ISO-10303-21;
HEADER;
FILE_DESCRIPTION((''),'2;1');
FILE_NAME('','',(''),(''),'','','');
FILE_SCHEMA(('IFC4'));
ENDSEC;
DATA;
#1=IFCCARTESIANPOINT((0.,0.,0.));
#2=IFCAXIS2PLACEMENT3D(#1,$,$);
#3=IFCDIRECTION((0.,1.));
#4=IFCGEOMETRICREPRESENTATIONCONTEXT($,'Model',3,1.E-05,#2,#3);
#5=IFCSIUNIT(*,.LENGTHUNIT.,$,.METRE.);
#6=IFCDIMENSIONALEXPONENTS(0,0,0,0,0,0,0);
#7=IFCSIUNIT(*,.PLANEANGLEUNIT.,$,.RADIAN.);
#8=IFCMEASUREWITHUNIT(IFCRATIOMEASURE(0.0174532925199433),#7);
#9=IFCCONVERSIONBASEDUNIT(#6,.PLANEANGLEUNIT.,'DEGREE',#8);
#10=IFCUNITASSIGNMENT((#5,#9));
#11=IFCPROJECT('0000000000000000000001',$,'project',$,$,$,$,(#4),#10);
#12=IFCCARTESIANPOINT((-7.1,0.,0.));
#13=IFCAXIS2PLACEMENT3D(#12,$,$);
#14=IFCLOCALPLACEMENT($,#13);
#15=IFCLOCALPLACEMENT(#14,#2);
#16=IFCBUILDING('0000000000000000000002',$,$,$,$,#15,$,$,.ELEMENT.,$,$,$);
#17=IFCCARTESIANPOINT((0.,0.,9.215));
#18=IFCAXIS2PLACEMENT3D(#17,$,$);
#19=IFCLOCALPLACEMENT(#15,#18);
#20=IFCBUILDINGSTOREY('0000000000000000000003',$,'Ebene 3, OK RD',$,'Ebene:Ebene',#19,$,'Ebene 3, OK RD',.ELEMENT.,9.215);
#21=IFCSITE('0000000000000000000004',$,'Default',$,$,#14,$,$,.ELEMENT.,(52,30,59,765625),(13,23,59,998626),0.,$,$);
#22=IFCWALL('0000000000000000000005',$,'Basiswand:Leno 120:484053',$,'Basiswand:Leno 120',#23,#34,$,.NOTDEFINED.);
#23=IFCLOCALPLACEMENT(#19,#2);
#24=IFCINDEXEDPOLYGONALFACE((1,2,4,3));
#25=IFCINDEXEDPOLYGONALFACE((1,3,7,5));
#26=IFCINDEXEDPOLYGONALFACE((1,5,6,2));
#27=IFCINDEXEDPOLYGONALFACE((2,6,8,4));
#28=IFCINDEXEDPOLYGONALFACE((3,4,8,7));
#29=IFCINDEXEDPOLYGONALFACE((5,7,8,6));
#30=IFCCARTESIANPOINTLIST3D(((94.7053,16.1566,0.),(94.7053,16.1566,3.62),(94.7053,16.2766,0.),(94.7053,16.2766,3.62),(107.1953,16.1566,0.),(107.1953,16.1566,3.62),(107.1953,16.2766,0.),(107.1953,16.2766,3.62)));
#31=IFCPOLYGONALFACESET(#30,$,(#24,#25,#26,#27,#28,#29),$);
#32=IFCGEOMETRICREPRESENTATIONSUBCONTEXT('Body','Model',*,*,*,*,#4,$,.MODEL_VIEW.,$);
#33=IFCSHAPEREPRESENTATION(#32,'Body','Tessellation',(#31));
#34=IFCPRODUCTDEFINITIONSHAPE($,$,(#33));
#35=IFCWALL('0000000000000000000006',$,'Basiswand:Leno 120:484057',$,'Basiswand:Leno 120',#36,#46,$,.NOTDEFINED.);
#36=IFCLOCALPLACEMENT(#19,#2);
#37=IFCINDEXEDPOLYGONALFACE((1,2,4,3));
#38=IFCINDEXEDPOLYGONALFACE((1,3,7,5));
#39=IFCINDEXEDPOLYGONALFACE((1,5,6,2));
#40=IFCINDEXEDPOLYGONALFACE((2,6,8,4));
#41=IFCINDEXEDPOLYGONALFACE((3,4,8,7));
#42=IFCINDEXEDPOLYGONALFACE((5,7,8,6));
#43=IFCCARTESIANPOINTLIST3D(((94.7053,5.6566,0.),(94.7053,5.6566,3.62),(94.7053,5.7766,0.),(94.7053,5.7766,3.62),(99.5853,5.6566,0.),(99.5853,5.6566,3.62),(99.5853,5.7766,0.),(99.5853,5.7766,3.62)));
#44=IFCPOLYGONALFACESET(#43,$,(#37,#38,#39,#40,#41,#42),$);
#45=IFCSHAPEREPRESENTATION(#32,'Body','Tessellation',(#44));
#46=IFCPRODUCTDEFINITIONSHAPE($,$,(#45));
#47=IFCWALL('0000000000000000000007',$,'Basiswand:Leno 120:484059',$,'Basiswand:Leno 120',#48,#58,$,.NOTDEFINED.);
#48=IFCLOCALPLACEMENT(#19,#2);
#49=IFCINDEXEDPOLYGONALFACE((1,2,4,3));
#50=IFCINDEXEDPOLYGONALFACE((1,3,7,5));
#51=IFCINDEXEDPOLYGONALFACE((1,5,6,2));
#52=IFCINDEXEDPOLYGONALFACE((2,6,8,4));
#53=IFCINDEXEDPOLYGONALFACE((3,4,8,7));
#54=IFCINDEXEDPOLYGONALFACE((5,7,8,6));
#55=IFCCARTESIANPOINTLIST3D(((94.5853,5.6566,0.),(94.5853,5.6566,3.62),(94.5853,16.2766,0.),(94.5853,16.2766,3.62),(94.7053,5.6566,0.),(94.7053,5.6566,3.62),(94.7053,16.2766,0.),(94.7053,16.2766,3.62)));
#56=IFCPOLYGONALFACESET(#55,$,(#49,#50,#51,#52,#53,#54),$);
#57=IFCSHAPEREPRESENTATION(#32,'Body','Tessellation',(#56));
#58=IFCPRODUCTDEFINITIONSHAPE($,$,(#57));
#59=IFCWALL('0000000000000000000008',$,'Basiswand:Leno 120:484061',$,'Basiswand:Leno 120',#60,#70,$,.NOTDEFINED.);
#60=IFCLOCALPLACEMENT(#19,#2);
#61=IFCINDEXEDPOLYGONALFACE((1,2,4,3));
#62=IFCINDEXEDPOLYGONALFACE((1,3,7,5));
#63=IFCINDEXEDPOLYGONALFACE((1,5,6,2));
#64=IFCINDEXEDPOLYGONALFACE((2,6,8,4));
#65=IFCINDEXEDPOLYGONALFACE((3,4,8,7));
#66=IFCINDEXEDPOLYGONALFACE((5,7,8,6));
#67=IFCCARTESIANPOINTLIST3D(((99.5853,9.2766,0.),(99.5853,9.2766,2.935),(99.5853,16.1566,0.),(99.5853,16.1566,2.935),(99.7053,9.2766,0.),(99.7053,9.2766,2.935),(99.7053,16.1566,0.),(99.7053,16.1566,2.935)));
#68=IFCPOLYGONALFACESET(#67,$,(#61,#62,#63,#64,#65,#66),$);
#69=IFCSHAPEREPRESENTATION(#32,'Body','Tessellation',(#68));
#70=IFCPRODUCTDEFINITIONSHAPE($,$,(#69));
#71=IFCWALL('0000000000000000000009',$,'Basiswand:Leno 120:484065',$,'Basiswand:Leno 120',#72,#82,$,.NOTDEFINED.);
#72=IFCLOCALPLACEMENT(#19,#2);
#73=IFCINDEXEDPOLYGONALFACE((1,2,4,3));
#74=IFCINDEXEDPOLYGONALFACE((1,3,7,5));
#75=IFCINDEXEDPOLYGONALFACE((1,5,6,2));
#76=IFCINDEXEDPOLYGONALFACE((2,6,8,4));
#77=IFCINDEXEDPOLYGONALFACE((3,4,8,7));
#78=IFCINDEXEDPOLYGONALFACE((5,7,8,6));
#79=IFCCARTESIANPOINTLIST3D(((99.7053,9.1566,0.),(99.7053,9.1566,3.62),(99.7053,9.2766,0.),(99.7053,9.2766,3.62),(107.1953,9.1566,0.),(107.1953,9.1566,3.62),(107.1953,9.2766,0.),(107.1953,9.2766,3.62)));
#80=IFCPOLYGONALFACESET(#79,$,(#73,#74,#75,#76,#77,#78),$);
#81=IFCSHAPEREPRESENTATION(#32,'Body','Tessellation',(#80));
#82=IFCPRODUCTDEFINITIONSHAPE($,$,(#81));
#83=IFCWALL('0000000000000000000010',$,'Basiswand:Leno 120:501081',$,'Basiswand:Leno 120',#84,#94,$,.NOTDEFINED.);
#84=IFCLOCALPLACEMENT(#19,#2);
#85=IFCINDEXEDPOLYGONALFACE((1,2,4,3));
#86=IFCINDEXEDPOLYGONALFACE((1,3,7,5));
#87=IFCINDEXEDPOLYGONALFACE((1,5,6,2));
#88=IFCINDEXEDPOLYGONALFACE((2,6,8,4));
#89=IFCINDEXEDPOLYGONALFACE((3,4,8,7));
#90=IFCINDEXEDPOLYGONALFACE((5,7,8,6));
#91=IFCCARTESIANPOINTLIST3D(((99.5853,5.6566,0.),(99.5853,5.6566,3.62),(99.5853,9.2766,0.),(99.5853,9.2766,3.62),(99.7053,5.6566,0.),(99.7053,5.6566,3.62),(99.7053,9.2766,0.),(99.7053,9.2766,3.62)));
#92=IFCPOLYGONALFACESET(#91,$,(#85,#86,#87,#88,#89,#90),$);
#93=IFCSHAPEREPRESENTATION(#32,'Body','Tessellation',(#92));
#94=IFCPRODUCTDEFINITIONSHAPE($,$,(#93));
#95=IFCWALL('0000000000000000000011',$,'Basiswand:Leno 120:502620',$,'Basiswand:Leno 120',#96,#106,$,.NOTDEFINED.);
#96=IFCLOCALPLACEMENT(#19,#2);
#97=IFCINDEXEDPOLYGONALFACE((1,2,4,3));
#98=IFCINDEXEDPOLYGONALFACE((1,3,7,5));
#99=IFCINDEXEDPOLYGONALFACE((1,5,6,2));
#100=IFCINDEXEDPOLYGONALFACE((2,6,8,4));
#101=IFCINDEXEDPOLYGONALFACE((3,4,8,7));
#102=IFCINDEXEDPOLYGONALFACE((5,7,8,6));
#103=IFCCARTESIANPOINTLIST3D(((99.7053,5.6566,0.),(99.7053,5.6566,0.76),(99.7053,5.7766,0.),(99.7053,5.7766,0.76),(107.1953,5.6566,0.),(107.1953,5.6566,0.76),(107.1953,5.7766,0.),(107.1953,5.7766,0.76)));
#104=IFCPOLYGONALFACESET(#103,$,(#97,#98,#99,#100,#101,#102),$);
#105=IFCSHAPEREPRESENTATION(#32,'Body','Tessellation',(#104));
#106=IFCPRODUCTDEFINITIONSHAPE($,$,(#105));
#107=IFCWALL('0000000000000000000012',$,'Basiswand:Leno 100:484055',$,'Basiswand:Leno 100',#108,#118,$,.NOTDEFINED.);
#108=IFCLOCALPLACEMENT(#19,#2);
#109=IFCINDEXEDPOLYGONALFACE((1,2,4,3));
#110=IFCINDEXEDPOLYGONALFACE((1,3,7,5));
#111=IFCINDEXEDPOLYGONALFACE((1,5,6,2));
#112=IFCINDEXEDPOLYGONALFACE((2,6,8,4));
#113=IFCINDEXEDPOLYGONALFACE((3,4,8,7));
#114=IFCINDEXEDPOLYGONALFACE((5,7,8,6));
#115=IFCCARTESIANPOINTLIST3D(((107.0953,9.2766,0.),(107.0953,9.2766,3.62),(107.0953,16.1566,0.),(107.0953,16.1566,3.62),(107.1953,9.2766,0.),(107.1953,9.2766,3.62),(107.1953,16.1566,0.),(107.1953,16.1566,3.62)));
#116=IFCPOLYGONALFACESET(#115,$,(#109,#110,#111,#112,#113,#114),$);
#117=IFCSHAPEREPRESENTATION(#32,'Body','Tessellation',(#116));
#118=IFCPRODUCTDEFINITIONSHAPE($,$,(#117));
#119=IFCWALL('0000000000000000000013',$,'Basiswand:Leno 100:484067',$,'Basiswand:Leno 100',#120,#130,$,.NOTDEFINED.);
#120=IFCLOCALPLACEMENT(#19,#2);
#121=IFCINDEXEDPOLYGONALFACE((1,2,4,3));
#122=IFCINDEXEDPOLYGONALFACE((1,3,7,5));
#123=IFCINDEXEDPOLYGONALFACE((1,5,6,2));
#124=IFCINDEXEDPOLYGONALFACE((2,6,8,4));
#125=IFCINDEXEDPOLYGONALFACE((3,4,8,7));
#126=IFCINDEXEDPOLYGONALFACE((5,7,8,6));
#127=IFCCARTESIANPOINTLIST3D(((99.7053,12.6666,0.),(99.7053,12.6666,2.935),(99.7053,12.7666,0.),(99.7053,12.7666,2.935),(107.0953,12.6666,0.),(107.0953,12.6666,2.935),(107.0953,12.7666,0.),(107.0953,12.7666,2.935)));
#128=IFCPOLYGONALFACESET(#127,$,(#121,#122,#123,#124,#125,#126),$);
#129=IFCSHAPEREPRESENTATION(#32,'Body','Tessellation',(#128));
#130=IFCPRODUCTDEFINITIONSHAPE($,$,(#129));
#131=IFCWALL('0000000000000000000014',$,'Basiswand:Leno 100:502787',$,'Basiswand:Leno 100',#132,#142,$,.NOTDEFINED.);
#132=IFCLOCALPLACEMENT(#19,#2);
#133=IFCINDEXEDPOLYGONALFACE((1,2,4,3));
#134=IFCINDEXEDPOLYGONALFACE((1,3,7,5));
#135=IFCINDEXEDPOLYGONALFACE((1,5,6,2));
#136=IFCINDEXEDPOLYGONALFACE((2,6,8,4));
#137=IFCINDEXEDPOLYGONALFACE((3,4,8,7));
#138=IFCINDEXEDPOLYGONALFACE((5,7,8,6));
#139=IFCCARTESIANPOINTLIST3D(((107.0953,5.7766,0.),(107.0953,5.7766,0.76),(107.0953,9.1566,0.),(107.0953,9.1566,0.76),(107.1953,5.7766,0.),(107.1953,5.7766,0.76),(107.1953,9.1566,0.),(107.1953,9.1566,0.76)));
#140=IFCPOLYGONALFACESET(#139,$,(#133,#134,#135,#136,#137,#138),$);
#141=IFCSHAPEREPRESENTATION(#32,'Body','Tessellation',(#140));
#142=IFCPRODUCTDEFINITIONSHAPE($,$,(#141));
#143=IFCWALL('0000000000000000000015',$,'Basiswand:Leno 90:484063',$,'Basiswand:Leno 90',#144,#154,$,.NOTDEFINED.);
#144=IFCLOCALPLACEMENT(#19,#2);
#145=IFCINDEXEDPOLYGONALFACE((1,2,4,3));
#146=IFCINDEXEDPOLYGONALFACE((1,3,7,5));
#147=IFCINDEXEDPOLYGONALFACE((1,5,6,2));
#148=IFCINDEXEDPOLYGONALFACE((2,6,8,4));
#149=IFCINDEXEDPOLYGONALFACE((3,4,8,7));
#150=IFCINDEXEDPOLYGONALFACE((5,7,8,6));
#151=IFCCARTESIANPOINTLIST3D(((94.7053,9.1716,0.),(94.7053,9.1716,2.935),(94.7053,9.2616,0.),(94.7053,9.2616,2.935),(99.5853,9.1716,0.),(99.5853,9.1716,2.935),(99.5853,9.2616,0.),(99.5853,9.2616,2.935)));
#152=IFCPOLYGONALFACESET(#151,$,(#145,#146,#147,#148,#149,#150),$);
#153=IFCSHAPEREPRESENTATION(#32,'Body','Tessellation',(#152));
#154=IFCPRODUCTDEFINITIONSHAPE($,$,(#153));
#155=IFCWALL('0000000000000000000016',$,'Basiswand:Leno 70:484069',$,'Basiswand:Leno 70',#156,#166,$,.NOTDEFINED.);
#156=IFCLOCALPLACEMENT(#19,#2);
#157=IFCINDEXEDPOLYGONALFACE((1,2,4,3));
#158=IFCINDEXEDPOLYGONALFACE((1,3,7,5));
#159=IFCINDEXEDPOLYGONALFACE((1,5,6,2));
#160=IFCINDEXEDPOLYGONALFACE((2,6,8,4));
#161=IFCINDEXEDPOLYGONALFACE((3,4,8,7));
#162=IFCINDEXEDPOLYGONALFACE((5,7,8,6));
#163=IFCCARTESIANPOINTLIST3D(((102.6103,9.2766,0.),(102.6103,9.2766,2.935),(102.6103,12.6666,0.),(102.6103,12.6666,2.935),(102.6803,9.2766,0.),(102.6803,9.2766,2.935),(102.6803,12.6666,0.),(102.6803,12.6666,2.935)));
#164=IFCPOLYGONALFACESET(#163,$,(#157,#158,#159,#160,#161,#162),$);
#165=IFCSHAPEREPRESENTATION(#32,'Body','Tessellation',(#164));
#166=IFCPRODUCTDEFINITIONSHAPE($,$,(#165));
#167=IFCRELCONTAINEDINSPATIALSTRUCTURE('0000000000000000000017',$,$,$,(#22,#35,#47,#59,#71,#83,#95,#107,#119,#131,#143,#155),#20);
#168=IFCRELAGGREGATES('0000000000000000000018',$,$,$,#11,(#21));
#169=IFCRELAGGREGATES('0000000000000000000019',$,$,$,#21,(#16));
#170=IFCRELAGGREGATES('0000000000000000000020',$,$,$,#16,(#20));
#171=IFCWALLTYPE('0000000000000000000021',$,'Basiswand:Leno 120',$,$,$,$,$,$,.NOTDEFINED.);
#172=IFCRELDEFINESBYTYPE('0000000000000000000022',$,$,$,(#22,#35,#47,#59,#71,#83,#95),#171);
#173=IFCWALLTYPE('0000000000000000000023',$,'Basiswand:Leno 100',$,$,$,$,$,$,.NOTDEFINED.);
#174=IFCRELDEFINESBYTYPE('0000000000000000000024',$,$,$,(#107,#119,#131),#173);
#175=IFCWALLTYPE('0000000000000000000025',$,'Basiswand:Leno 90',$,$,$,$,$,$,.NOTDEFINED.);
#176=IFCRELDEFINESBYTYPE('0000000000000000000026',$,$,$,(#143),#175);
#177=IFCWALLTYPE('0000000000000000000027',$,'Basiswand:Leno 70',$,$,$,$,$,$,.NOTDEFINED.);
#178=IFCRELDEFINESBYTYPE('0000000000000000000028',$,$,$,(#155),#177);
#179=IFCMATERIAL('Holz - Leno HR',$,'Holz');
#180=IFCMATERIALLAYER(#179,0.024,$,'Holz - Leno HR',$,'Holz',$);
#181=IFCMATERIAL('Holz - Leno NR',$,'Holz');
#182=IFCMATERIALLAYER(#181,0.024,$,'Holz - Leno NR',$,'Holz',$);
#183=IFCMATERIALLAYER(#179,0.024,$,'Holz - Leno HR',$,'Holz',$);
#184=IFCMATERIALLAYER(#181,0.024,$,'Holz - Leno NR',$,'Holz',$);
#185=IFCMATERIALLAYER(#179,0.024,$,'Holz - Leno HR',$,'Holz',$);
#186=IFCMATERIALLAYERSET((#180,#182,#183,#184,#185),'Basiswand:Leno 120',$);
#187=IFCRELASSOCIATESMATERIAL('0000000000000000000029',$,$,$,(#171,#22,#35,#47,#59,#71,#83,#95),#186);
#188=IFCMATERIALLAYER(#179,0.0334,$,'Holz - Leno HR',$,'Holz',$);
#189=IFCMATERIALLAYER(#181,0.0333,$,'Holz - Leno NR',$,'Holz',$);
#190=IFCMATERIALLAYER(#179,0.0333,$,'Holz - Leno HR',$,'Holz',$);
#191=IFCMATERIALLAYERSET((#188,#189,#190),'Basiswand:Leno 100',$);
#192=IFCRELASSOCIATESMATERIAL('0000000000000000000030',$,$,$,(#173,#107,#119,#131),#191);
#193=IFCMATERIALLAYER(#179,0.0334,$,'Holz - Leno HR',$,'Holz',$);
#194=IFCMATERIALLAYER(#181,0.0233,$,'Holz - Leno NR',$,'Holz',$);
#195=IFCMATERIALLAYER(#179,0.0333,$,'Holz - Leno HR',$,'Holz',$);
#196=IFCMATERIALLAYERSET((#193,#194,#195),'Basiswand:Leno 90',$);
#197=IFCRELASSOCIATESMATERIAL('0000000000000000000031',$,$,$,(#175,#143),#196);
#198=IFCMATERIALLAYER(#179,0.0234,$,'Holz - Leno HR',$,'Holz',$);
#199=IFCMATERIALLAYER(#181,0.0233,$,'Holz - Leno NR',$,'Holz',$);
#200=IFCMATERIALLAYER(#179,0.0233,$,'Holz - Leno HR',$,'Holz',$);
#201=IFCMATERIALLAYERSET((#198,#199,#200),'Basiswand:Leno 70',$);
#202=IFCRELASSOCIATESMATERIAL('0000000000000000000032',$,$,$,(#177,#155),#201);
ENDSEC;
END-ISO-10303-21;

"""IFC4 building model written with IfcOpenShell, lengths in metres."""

from ifc_helpers import new_model, entity, si_unit, converted_unit, direction, frame, frame_2d, origin, place, context, subcontext, project, spatial, rectangle, extrude, material, layer, layer_set, layer_usage, type_object, element, save


model = new_model("IFC4")

# Units and contexts
model_context = context("Model", 3, precision=1e-05, world=origin(), true_north=direction((0.0, 1.0)))
body_context = subcontext(model_context, "Body", "Model", "MODEL_VIEW")
ifc_project = project(units=[si_unit("LENGTHUNIT", "METRE"), converted_unit("PLANEANGLEUNIT", "DEGREE", entity("IfcRatioMeasure", 0.0174532925199433), si_unit("PLANEANGLEUNIT", "RADIAN"), dimensions=[0, 0, 0, 0, 0, 0, 0])], contexts=[model_context])

# Site, building, storey
site_placement = place(None, frame((-7.1, 0.0, 0.0)))
site = spatial("IfcSite", under=ifc_project, at=site_placement, Name="Default", CompositionType="ELEMENT", RefLatitude=(52, 30, 59, 765625), RefLongitude=(13, 23, 59, 998626), RefElevation=0.0)
building_placement = place(site_placement, origin())
building = spatial("IfcBuilding", under=site, at=building_placement, CompositionType="ELEMENT")
storey_placement = place(building_placement, frame((0.0, 0.0, 9.215)))
storey = spatial("IfcBuildingStorey", under=building, at=storey_placement, Name="Ebene 3, OK RD", ObjectType="Ebene:Ebene", LongName="Ebene 3, OK RD", CompositionType="ELEMENT", Elevation=9.215)

# Shared definitions
ifc_material_1 = material(Name="Holz - Leno HR", Category="Holz")
ifc_material_2 = material(Name="Holz - Leno NR", Category="Holz")

# Walls
ifc_layer_1 = layer(ifc_material_1, 0.024, Name="Holz - Leno HR", Category="Holz")
ifc_layer_2 = layer(ifc_material_2, 0.024, Name="Holz - Leno NR", Category="Holz")
ifc_layer_3 = layer(ifc_material_1, 0.024, Name="Holz - Leno HR", Category="Holz")
ifc_layer_4 = layer(ifc_material_2, 0.024, Name="Holz - Leno NR", Category="Holz")
ifc_layer_5 = layer(ifc_material_1, 0.024, Name="Holz - Leno HR", Category="Holz")
ifc_layer_set_1 = layer_set([ifc_layer_1, ifc_layer_2, ifc_layer_3, ifc_layer_4, ifc_layer_5], Name="Basiswand:Leno 120")
ifc_layer_usage_1 = layer_usage(ifc_layer_set_1, "AXIS2", "NEGATIVE", 0.06)
wall_type_1 = type_object("IfcWallType", Name="Basiswand:Leno 120", PredefinedType="NOTDEFINED", material=ifc_layer_set_1)
wall_1_placement = place(storey_placement, frame((94.7053, 16.2166, 0.0)))
element("IfcWall", 1, at=wall_1_placement, inside=storey, type_object=wall_type_1, material=ifc_layer_usage_1, Name="Basiswand:Leno 120:484053", ObjectType="Basiswand:Leno 120", PredefinedType="NOTDEFINED", context=body_context, shape_type="SweptSolid", body=[
    extrude(rectangle(XDim=12.49, YDim=0.12, at=frame_2d((6.245, 0.0), x_axis=(-1.0, 0.0))), origin(), (0.0, 0.0, 1.0), 3.62),
])
ifc_layer_usage_2 = layer_usage(ifc_layer_set_1, "AXIS2", "NEGATIVE", 0.06)
wall_2_placement = place(storey_placement, frame((99.5853, 5.7166, 0.0), z_axis=(0.0, 0.0, 1.0), x_axis=(-1.0, 0.0, 0.0)))
element("IfcWall", 2, at=wall_2_placement, inside=storey, type_object=wall_type_1, material=ifc_layer_usage_2, Name="Basiswand:Leno 120:484057", ObjectType="Basiswand:Leno 120", PredefinedType="NOTDEFINED", context=body_context, shape_type="SweptSolid", body=[
    extrude(rectangle(XDim=4.88, YDim=0.12, at=frame_2d((2.44, 0.0), x_axis=(-1.0, 0.0))), origin(), (0.0, 0.0, 1.0), 3.62),
])
ifc_layer_usage_3 = layer_usage(ifc_layer_set_1, "AXIS2", "NEGATIVE", 0.06)
wall_3_placement = place(storey_placement, frame((94.6453, 5.6566, 0.0), z_axis=(0.0, 0.0, 1.0), x_axis=(0.0, 1.0, 0.0)))
element("IfcWall", 3, at=wall_3_placement, inside=storey, type_object=wall_type_1, material=ifc_layer_usage_3, Name="Basiswand:Leno 120:484059", ObjectType="Basiswand:Leno 120", PredefinedType="NOTDEFINED", context=body_context, shape_type="SweptSolid", body=[
    extrude(rectangle(XDim=10.62, YDim=0.12, at=frame_2d((5.31, 0.0), x_axis=(-1.0, 0.0))), origin(), (0.0, 0.0, 1.0), 3.62),
])
ifc_layer_usage_4 = layer_usage(ifc_layer_set_1, "AXIS2", "NEGATIVE", 0.06)
wall_4_placement = place(storey_placement, frame((99.6453, 16.1566, 0.0), z_axis=(0.0, 0.0, 1.0), x_axis=(0.0, -1.0, 0.0)))
element("IfcWall", 4, at=wall_4_placement, inside=storey, type_object=wall_type_1, material=ifc_layer_usage_4, Name="Basiswand:Leno 120:484061", ObjectType="Basiswand:Leno 120", PredefinedType="NOTDEFINED", context=body_context, shape_type="SweptSolid", body=[
    extrude(rectangle(XDim=6.88, YDim=0.12, at=frame_2d((3.44, 0.0), x_axis=(-1.0, 0.0))), origin(), (0.0, 0.0, 1.0), 2.935),
])
ifc_layer_usage_5 = layer_usage(ifc_layer_set_1, "AXIS2", "NEGATIVE", 0.06)
wall_5_placement = place(storey_placement, frame((107.1953, 9.2166, 0.0), z_axis=(0.0, 0.0, 1.0), x_axis=(-1.0, 0.0, 0.0)))
element("IfcWall", 5, at=wall_5_placement, inside=storey, type_object=wall_type_1, material=ifc_layer_usage_5, Name="Basiswand:Leno 120:484065", ObjectType="Basiswand:Leno 120", PredefinedType="NOTDEFINED", context=body_context, shape_type="SweptSolid", body=[
    extrude(rectangle(XDim=7.49, YDim=0.12, at=frame_2d((3.745, 0.0), x_axis=(-1.0, 0.0))), origin(), (0.0, 0.0, 1.0), 3.62),
])
ifc_layer_usage_6 = layer_usage(ifc_layer_set_1, "AXIS2", "NEGATIVE", 0.06)
wall_6_placement = place(storey_placement, frame((99.6453, 9.2766, 0.0), z_axis=(0.0, 0.0, 1.0), x_axis=(0.0, -1.0, 0.0)))
element("IfcWall", 6, at=wall_6_placement, inside=storey, type_object=wall_type_1, material=ifc_layer_usage_6, Name="Basiswand:Leno 120:501081", ObjectType="Basiswand:Leno 120", PredefinedType="NOTDEFINED", context=body_context, shape_type="SweptSolid", body=[
    extrude(rectangle(XDim=3.62, YDim=0.12, at=frame_2d((1.81, 0.0), x_axis=(-1.0, 0.0))), origin(), (0.0, 0.0, 1.0), 3.62),
])
ifc_layer_usage_7 = layer_usage(ifc_layer_set_1, "AXIS2", "NEGATIVE", 0.06)
wall_7_placement = place(storey_placement, frame((99.7053, 5.7166, 0.0)))
element("IfcWall", 7, at=wall_7_placement, inside=storey, type_object=wall_type_1, material=ifc_layer_usage_7, Name="Basiswand:Leno 120:502620", ObjectType="Basiswand:Leno 120", PredefinedType="NOTDEFINED", context=body_context, shape_type="SweptSolid", body=[
    extrude(rectangle(XDim=7.49, YDim=0.12, at=frame_2d((3.745, 0.0), x_axis=(-1.0, 0.0))), origin(), (0.0, 0.0, 1.0), 0.76),
])
ifc_layer_6 = layer(ifc_material_1, 0.0334, Name="Holz - Leno HR", Category="Holz")
ifc_layer_7 = layer(ifc_material_2, 0.0333, Name="Holz - Leno NR", Category="Holz")
ifc_layer_8 = layer(ifc_material_1, 0.0333, Name="Holz - Leno HR", Category="Holz")
ifc_layer_set_2 = layer_set([ifc_layer_6, ifc_layer_7, ifc_layer_8], Name="Basiswand:Leno 100")
ifc_layer_usage_8 = layer_usage(ifc_layer_set_2, "AXIS2", "NEGATIVE", 0.05)
wall_type_2 = type_object("IfcWallType", Name="Basiswand:Leno 100", PredefinedType="NOTDEFINED", material=ifc_layer_set_2)
wall_8_placement = place(storey_placement, frame((107.1453, 16.1566, 0.0), z_axis=(0.0, 0.0, 1.0), x_axis=(0.0, -1.0, 0.0)))
element("IfcWall", 8, at=wall_8_placement, inside=storey, type_object=wall_type_2, material=ifc_layer_usage_8, Name="Basiswand:Leno 100:484055", ObjectType="Basiswand:Leno 100", PredefinedType="NOTDEFINED", context=body_context, shape_type="SweptSolid", body=[
    extrude(rectangle(XDim=6.88, YDim=0.1, at=frame_2d((3.44, 0.0), x_axis=(-1.0, 0.0))), origin(), (0.0, 0.0, 1.0), 3.62),
])
ifc_layer_usage_9 = layer_usage(ifc_layer_set_2, "AXIS2", "NEGATIVE", 0.05)
wall_9_placement = place(storey_placement, frame((107.0953, 12.7166, 0.0), z_axis=(0.0, 0.0, 1.0), x_axis=(-1.0, 0.0, 0.0)))
element("IfcWall", 9, at=wall_9_placement, inside=storey, type_object=wall_type_2, material=ifc_layer_usage_9, Name="Basiswand:Leno 100:484067", ObjectType="Basiswand:Leno 100", PredefinedType="NOTDEFINED", context=body_context, shape_type="SweptSolid", body=[
    extrude(rectangle(XDim=7.39, YDim=0.1, at=frame_2d((3.695, 0.0), x_axis=(-1.0, 0.0))), origin(), (0.0, 0.0, 1.0), 2.935),
])
ifc_layer_usage_10 = layer_usage(ifc_layer_set_2, "AXIS2", "NEGATIVE", 0.05)
wall_10_placement = place(storey_placement, frame((107.1453, 5.7766, 0.0), z_axis=(0.0, 0.0, 1.0), x_axis=(0.0, 1.0, 0.0)))
element("IfcWall", 10, at=wall_10_placement, inside=storey, type_object=wall_type_2, material=ifc_layer_usage_10, Name="Basiswand:Leno 100:502787", ObjectType="Basiswand:Leno 100", PredefinedType="NOTDEFINED", context=body_context, shape_type="SweptSolid", body=[
    extrude(rectangle(XDim=3.38, YDim=0.1, at=frame_2d((1.69, 0.0), x_axis=(-1.0, 0.0))), origin(), (0.0, 0.0, 1.0), 0.76),
])
ifc_layer_9 = layer(ifc_material_1, 0.0334, Name="Holz - Leno HR", Category="Holz")
ifc_layer_10 = layer(ifc_material_2, 0.0233, Name="Holz - Leno NR", Category="Holz")
ifc_layer_11 = layer(ifc_material_1, 0.0333, Name="Holz - Leno HR", Category="Holz")
ifc_layer_set_3 = layer_set([ifc_layer_9, ifc_layer_10, ifc_layer_11], Name="Basiswand:Leno 90")
ifc_layer_usage_11 = layer_usage(ifc_layer_set_3, "AXIS2", "NEGATIVE", 0.045)
wall_type_3 = type_object("IfcWallType", Name="Basiswand:Leno 90", PredefinedType="NOTDEFINED", material=ifc_layer_set_3)
wall_11_placement = place(storey_placement, frame((94.7053, 9.2166, 0.0)))
element("IfcWall", 11, at=wall_11_placement, inside=storey, type_object=wall_type_3, material=ifc_layer_usage_11, Name="Basiswand:Leno 90:484063", ObjectType="Basiswand:Leno 90", PredefinedType="NOTDEFINED", context=body_context, shape_type="SweptSolid", body=[
    extrude(rectangle(XDim=4.88, YDim=0.09, at=frame_2d((2.44, 0.0), x_axis=(-1.0, 0.0))), origin(), (0.0, 0.0, 1.0), 2.935),
])
ifc_layer_12 = layer(ifc_material_1, 0.0234, Name="Holz - Leno HR", Category="Holz")
ifc_layer_13 = layer(ifc_material_2, 0.0233, Name="Holz - Leno NR", Category="Holz")
ifc_layer_14 = layer(ifc_material_1, 0.0233, Name="Holz - Leno HR", Category="Holz")
ifc_layer_set_4 = layer_set([ifc_layer_12, ifc_layer_13, ifc_layer_14], Name="Basiswand:Leno 70")
ifc_layer_usage_12 = layer_usage(ifc_layer_set_4, "AXIS2", "NEGATIVE", 0.035)
wall_type_4 = type_object("IfcWallType", Name="Basiswand:Leno 70", PredefinedType="NOTDEFINED", material=ifc_layer_set_4)
wall_12_placement = place(storey_placement, frame((102.6453, 9.2766, 0.0), z_axis=(0.0, 0.0, 1.0), x_axis=(0.0, 1.0, 0.0)))
element("IfcWall", 12, at=wall_12_placement, inside=storey, type_object=wall_type_4, material=ifc_layer_usage_12, Name="Basiswand:Leno 70:484069", ObjectType="Basiswand:Leno 70", PredefinedType="NOTDEFINED", context=body_context, shape_type="SweptSolid", body=[
    extrude(rectangle(XDim=3.39, YDim=0.07, at=frame_2d((1.695, 0.0), x_axis=(-1.0, 0.0))), origin(), (0.0, 0.0, 1.0), 2.935),
])

save(model, "model.ifc")
